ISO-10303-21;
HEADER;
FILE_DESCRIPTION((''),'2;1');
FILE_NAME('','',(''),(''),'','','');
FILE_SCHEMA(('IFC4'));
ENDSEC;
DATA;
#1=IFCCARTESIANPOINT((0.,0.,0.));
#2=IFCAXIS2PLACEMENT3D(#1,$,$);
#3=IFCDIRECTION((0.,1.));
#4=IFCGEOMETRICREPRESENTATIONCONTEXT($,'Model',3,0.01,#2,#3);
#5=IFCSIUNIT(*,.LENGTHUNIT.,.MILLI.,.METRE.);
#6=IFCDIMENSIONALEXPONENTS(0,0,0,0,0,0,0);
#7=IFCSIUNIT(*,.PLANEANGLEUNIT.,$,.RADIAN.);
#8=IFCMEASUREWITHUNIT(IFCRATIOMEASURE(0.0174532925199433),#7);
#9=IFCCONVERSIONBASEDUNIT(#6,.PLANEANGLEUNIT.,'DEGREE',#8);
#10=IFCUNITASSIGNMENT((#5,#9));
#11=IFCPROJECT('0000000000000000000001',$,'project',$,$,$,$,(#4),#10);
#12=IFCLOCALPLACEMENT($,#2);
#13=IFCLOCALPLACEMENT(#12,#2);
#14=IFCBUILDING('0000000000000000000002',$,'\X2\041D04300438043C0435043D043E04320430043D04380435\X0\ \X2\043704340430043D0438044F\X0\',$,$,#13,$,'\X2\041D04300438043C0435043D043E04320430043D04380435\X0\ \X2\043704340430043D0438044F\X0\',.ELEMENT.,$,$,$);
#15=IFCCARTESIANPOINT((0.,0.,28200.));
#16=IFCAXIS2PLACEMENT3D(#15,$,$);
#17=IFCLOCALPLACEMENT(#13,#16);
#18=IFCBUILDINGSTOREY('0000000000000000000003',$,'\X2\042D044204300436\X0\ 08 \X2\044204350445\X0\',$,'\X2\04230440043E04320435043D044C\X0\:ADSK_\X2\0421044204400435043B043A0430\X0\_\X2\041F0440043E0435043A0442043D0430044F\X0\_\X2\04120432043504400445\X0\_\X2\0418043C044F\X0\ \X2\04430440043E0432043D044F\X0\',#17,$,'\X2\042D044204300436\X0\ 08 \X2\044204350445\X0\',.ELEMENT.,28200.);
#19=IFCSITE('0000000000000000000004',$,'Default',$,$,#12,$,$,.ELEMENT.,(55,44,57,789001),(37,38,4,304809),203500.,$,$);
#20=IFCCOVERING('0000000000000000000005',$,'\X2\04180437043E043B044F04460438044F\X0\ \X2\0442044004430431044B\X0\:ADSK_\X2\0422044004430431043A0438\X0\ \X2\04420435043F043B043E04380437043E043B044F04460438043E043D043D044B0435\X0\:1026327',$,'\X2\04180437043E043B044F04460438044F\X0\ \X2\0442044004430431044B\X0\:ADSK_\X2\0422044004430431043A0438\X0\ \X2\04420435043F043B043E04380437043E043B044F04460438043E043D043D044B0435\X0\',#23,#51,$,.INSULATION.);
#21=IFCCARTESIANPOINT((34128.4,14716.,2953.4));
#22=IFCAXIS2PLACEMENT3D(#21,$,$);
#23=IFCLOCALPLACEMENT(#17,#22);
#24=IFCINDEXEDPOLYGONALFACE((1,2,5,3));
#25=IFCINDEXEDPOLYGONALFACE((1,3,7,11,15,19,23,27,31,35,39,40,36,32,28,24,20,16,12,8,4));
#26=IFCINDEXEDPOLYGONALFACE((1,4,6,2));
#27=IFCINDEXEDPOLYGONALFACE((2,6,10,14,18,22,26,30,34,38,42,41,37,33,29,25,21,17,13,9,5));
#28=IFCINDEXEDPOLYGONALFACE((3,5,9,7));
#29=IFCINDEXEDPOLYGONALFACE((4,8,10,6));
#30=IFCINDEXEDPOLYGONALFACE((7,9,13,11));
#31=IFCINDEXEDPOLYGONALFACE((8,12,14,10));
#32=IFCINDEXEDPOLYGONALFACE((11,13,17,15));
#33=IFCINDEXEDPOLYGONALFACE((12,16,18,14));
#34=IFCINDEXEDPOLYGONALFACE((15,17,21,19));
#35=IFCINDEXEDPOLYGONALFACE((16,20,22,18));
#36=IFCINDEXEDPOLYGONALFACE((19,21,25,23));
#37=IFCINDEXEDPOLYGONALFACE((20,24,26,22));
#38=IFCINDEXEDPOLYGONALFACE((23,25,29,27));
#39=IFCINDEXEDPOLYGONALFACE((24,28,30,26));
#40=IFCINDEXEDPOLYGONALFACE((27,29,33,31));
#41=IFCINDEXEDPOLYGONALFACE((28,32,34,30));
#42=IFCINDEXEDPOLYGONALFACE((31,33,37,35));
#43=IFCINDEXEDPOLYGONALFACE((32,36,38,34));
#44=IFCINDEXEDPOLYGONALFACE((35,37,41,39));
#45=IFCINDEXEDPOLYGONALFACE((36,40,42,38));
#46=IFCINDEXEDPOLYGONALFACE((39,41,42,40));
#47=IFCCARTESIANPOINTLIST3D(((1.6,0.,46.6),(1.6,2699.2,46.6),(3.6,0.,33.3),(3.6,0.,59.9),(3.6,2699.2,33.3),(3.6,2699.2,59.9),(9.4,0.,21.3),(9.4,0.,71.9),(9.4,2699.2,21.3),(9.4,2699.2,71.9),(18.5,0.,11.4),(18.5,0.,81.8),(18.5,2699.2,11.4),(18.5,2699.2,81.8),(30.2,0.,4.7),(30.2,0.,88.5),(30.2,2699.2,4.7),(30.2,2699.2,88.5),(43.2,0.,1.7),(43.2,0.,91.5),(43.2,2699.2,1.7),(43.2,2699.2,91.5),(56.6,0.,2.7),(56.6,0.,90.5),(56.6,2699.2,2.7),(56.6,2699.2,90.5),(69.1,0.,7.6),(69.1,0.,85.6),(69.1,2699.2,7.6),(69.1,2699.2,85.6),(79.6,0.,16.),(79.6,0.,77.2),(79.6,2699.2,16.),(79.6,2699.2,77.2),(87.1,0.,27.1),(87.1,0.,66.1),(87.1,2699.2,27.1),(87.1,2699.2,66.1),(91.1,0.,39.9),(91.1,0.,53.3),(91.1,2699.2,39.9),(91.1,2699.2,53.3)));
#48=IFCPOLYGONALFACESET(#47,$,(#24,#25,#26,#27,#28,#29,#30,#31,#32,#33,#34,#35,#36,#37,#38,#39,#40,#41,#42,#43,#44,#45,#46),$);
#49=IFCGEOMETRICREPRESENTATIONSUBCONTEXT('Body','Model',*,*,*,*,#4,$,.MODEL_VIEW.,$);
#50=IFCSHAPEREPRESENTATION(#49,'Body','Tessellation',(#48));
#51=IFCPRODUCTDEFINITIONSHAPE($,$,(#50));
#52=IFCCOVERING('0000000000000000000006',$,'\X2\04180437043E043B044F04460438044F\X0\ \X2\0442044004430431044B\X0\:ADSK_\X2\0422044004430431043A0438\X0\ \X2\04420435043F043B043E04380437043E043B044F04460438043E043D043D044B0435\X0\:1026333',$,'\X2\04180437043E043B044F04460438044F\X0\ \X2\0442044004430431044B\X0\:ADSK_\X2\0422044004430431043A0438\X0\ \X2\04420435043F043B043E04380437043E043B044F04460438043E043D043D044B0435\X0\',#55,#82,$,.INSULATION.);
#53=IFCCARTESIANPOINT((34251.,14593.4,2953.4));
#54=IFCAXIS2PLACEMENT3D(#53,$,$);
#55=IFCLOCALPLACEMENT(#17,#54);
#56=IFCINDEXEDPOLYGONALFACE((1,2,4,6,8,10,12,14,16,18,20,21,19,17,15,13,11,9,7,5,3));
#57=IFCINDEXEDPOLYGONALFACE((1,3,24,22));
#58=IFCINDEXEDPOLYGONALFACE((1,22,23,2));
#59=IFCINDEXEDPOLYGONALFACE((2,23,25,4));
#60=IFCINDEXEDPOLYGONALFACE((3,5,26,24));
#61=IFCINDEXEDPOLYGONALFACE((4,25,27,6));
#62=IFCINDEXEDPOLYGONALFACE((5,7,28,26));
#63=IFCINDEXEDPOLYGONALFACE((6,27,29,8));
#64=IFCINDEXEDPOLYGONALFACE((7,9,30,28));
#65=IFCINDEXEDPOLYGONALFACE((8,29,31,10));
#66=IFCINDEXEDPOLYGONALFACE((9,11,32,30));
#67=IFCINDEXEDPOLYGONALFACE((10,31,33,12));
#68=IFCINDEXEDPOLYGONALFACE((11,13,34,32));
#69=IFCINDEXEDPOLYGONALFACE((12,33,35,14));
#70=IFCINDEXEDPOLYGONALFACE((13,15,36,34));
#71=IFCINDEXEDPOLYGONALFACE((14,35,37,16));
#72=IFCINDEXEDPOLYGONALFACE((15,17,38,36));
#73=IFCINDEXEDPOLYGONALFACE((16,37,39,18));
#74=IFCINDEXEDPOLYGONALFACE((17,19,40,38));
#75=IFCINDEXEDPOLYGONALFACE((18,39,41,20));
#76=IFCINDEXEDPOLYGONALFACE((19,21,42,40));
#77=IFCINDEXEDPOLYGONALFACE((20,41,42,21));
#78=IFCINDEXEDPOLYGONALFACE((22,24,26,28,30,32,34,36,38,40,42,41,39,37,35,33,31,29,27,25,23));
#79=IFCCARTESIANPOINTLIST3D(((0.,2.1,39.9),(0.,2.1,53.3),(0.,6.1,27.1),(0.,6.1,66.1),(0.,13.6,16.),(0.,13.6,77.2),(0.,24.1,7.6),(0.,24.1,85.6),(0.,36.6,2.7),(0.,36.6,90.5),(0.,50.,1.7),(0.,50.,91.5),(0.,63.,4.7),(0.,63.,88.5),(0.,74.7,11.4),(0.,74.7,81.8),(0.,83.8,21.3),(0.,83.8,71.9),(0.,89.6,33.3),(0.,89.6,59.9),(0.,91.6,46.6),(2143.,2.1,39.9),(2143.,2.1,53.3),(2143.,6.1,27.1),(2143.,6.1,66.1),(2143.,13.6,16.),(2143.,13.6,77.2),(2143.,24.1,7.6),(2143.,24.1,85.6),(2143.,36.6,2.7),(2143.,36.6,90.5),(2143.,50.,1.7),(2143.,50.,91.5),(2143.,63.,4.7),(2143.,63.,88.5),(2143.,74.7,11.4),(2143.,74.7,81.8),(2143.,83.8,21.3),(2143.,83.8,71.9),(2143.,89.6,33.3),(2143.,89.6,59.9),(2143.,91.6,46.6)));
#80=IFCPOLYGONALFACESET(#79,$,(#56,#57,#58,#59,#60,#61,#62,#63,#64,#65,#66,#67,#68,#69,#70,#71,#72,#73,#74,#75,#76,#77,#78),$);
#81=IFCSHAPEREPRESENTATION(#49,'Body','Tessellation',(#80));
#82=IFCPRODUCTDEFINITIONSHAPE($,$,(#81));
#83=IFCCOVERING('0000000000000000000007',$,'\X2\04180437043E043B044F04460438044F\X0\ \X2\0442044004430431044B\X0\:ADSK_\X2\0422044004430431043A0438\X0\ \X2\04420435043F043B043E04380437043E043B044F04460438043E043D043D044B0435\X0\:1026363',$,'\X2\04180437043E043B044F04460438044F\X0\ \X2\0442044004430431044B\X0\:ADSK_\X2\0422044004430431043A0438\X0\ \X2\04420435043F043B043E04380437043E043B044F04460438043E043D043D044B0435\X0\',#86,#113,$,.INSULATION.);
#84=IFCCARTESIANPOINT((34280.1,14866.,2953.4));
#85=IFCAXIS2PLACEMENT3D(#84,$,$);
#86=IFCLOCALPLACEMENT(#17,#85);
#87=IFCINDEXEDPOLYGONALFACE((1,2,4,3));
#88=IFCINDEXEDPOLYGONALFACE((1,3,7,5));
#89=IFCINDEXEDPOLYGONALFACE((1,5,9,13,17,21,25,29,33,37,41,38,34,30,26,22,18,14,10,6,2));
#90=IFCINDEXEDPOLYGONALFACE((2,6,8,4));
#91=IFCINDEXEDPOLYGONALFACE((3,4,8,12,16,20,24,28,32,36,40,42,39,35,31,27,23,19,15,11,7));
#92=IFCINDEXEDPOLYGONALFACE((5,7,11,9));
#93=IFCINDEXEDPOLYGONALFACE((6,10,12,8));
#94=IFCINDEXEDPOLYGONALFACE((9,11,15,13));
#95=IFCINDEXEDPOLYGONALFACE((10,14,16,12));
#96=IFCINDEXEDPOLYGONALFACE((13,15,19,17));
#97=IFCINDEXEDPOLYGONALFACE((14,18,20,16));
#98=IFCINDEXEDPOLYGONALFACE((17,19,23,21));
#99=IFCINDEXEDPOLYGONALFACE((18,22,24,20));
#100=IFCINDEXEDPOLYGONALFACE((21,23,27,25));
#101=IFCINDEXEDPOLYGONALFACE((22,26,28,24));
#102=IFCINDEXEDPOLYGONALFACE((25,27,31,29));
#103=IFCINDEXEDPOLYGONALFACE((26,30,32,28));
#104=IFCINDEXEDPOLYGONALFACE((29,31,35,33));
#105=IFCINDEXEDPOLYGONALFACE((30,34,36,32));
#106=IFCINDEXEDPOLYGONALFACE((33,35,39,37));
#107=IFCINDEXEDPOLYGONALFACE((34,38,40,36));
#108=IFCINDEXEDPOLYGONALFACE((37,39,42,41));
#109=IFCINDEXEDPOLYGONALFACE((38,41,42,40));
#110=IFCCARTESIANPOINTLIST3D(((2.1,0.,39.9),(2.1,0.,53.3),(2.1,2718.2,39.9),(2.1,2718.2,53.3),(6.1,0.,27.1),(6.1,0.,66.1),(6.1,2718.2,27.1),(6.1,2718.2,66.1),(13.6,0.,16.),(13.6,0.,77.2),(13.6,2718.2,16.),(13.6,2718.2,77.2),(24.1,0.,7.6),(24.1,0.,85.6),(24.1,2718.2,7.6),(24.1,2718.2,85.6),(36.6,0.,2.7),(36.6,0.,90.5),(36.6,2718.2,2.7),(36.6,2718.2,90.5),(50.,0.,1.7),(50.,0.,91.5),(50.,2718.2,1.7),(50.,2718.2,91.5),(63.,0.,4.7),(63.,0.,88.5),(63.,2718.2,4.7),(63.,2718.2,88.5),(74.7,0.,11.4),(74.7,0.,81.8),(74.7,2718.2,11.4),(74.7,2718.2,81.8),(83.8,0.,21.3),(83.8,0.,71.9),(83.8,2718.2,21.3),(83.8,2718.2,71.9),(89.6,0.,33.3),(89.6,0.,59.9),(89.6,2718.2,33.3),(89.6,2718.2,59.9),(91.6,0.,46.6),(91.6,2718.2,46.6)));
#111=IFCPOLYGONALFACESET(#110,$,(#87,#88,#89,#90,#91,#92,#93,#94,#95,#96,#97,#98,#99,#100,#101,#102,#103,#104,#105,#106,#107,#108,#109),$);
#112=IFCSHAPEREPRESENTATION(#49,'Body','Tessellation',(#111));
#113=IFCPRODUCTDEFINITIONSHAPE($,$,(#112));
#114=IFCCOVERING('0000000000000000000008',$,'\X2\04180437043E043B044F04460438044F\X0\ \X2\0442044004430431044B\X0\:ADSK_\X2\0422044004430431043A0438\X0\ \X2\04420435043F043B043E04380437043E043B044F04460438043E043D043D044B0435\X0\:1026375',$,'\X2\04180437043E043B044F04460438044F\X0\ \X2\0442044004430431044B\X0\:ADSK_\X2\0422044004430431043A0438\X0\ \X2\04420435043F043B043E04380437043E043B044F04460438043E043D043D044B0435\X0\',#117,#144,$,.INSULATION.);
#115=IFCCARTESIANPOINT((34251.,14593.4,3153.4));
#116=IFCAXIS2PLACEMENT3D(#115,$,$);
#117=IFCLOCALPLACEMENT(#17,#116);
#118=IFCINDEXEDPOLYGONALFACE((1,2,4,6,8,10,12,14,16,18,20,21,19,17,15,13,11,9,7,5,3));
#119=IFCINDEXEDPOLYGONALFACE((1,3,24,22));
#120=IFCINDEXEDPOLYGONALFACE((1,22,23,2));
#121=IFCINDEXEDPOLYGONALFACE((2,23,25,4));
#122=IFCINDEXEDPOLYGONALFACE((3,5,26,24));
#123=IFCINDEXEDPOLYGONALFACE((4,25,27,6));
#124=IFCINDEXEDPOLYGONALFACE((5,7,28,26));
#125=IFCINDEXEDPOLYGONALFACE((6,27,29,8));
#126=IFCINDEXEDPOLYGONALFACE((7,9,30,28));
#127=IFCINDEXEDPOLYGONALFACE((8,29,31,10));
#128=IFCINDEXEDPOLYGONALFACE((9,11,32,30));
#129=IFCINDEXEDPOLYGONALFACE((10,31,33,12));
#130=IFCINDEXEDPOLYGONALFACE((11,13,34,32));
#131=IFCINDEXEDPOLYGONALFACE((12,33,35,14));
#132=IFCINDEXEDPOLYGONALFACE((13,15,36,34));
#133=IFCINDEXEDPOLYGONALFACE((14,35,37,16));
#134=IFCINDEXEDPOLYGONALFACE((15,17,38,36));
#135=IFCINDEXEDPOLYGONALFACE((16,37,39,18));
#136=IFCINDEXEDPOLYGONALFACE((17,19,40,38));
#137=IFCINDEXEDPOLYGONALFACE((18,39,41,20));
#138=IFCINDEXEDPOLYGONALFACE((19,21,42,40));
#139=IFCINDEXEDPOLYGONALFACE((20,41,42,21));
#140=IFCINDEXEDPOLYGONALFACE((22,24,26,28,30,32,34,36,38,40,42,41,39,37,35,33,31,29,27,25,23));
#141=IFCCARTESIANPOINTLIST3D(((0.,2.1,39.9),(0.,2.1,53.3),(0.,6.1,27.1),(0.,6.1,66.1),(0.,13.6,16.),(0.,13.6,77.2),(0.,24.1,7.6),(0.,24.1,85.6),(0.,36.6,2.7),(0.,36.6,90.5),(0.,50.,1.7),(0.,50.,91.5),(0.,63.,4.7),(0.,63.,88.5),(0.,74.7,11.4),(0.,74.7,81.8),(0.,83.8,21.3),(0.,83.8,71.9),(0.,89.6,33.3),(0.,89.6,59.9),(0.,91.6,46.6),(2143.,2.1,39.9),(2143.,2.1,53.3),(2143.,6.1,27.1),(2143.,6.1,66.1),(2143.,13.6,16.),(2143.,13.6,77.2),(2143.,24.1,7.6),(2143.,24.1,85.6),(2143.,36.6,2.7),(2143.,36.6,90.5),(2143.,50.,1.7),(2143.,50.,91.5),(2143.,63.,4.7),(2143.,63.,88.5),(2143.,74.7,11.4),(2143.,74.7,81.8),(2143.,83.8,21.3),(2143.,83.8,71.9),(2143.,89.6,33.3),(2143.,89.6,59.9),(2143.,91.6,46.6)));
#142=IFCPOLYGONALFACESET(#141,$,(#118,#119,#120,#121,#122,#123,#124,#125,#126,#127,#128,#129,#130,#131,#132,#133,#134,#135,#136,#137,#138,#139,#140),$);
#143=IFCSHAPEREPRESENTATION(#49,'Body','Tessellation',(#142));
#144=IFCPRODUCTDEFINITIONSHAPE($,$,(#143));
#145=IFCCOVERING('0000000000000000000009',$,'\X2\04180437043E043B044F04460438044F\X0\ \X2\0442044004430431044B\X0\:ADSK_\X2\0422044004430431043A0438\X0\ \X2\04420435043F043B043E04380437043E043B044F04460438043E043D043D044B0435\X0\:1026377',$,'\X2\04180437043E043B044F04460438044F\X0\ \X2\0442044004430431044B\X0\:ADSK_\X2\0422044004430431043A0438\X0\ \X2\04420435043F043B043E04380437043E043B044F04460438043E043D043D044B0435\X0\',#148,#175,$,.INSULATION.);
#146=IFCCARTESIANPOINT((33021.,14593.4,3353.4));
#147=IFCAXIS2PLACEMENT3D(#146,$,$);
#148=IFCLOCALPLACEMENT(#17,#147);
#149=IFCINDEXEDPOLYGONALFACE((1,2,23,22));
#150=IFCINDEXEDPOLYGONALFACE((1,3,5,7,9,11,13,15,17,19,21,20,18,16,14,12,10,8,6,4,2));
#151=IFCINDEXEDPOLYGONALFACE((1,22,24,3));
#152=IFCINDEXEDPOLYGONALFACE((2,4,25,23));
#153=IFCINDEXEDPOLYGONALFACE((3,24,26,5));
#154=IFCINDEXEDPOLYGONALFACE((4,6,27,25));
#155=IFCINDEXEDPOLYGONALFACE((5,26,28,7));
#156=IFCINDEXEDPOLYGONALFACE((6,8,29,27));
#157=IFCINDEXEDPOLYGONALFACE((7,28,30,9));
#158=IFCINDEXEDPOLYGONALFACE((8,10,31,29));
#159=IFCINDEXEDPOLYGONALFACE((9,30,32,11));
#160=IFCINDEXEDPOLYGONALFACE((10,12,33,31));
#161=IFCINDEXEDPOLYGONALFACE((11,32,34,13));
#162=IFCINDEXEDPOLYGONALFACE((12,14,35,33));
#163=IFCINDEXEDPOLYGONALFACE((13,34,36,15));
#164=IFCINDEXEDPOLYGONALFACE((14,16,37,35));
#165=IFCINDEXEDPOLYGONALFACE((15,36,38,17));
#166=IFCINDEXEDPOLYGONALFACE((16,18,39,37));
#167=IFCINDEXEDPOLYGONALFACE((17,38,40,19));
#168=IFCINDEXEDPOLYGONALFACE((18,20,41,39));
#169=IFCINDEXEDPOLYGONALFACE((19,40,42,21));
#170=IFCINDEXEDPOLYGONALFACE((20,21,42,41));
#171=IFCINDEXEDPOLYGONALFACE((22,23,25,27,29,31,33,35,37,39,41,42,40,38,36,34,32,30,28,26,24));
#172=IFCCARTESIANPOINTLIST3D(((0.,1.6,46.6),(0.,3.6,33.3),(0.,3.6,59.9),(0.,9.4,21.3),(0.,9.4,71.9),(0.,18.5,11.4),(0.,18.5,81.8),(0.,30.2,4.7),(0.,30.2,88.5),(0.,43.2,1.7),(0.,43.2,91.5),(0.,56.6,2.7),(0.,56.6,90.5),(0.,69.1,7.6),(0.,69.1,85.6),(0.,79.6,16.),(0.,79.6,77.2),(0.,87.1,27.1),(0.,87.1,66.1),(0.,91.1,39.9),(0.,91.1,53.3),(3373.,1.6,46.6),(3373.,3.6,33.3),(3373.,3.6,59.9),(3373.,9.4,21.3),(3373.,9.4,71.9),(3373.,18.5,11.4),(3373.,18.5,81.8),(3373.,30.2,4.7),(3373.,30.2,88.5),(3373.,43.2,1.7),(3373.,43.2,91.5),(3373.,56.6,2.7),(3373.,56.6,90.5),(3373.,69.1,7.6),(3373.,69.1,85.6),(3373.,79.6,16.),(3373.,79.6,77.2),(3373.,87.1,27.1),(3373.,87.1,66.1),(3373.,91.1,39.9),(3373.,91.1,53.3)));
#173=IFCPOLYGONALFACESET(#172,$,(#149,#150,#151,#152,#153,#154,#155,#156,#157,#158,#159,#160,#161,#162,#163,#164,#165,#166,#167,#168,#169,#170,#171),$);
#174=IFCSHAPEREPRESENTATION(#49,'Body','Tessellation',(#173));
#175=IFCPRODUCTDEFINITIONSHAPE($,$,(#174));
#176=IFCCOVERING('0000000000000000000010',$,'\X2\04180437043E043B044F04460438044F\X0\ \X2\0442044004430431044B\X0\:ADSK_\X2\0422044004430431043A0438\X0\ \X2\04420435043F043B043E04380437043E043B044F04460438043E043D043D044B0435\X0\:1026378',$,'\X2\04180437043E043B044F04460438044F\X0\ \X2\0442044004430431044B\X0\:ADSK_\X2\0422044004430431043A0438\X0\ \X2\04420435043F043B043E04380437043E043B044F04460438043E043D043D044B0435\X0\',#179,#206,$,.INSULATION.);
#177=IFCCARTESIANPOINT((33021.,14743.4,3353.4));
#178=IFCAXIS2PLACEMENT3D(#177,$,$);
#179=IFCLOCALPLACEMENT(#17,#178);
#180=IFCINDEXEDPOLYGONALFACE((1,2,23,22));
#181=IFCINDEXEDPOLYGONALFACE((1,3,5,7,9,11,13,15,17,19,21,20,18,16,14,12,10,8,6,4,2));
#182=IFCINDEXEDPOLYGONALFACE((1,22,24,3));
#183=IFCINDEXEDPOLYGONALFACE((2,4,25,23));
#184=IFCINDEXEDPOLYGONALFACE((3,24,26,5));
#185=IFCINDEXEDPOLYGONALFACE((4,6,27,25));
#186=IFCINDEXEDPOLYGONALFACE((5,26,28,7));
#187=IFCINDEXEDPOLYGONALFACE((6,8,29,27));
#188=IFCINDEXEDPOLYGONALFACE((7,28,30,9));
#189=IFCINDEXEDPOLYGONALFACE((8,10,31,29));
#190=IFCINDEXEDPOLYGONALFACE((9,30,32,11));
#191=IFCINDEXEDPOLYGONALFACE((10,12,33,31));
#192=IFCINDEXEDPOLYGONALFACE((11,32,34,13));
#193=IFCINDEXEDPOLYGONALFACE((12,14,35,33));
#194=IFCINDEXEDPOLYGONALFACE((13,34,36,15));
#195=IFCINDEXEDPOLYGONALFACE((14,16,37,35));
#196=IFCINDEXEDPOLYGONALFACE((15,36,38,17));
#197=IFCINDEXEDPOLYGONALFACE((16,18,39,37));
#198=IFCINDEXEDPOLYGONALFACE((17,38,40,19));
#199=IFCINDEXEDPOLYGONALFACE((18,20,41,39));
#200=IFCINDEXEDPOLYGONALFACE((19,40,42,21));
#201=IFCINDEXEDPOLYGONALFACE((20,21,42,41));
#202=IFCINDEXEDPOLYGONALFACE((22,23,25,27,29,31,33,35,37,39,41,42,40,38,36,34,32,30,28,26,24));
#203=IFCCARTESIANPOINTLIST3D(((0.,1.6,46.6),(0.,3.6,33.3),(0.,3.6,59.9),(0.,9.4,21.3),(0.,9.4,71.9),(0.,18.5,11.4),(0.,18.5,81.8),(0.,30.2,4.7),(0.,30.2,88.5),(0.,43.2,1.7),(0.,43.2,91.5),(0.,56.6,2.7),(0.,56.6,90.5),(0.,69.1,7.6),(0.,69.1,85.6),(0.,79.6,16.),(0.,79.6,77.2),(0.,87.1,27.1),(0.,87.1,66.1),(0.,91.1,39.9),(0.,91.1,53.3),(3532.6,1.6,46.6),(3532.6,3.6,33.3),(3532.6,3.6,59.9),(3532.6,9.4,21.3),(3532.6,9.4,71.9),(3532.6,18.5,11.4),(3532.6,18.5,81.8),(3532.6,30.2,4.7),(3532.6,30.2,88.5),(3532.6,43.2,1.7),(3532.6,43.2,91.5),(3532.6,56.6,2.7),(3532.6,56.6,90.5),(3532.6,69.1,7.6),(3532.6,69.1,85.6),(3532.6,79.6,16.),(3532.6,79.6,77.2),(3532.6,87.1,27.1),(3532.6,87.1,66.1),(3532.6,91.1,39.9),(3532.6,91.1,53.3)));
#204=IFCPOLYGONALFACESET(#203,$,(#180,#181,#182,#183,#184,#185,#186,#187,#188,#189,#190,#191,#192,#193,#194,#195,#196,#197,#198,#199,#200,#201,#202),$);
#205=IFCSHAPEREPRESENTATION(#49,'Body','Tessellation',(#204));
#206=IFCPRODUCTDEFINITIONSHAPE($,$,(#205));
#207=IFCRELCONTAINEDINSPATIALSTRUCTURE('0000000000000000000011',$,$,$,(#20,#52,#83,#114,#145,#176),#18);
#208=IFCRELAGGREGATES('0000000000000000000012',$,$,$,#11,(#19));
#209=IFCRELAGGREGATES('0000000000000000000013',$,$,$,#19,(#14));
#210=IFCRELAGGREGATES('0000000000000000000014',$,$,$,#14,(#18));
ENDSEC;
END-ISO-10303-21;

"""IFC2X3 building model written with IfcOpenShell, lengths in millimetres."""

from ifc_helpers import new_model, entity, si_unit, converted_unit, direction, frame, origin, origin_2d_with_axis, place, context, subcontext, project, spatial, circle, extrude, element, save


model = new_model("IFC2X3")

# Units and contexts
model_context = context("Model", 3, precision=0.01, world=origin(), true_north=direction((0.0, 1.0)))
body_context = subcontext(model_context, "Body", "Model", "MODEL_VIEW")
ifc_project = project(units=[si_unit("LENGTHUNIT", "METRE", prefix="MILLI"), converted_unit("PLANEANGLEUNIT", "DEGREE", entity("IfcRatioMeasure", 0.0174532925199433), si_unit("PLANEANGLEUNIT", "RADIAN"), dimensions=[0, 0, 0, 0, 0, 0, 0])], contexts=[model_context])

# Site, building, storey
site_placement = place(None, origin())
site = spatial("IfcSite", under=ifc_project, at=site_placement, Name="Default", CompositionType="ELEMENT", RefLatitude=(55, 44, 57, 789001), RefLongitude=(37, 38, 4, 304809), RefElevation=203500.0)
building_placement = place(site_placement, origin())
building = spatial("IfcBuilding", under=site, at=building_placement, Name="Наименование здания", LongName="Наименование здания", CompositionType="ELEMENT")
storey_placement = place(building_placement, frame((0.0, 0.0, 28200.0)))
storey = spatial("IfcBuildingStorey", under=building, at=storey_placement, Name="Этаж 08 тех", ObjectType="Уровень:ADSK_Стрелка_Проектная_Вверх_Имя уровня", LongName="Этаж 08 тех", CompositionType="ELEMENT", Elevation=28200.0)

# Coverings
covering_1_placement = place(storey_placement, frame((34128.4, 14716.0, 2953.4)))
element("IfcCovering", 1, at=covering_1_placement, inside=storey, Name="Изоляция трубы:ADSK_Трубки теплоизоляционные:1026327", ObjectType="Изоляция трубы:ADSK_Трубки теплоизоляционные", PredefinedType="INSULATION", context=body_context, shape_type="SweptSolid", body=[
    extrude(circle(Radius=45.0, at=origin_2d_with_axis()), frame((46.6, 0.0, 46.6), z_axis=(0.0, 1.0, 0.0), x_axis=(-1.0, 0.0, 0.0)), (0.0, 0.0, 1.0), 2699.2),
])
covering_2_placement = place(storey_placement, frame((34251.0, 14593.4, 2953.4)))
element("IfcCovering", 2, at=covering_2_placement, inside=storey, Name="Изоляция трубы:ADSK_Трубки теплоизоляционные:1026333", ObjectType="Изоляция трубы:ADSK_Трубки теплоизоляционные", PredefinedType="INSULATION", context=body_context, shape_type="SweptSolid", body=[
    extrude(circle(Radius=45.0, at=origin_2d_with_axis()), frame((0.0, 46.6, 46.6), z_axis=(1.0, 0.0, 0.0), x_axis=(0.0, 1.0, 0.0)), (0.0, 0.0, 1.0), 2143.0),
])
covering_3_placement = place(storey_placement, frame((34280.1, 14866.0, 2953.4)))
element("IfcCovering", 3, at=covering_3_placement, inside=storey, Name="Изоляция трубы:ADSK_Трубки теплоизоляционные:1026363", ObjectType="Изоляция трубы:ADSK_Трубки теплоизоляционные", PredefinedType="INSULATION", context=body_context, shape_type="SweptSolid", body=[
    extrude(circle(Radius=45.0, at=origin_2d_with_axis()), frame((46.6, 0.0, 46.6), z_axis=(0.0, 1.0, 0.0), x_axis=(1.0, 0.0, 0.0)), (0.0, 0.0, 1.0), 2718.2),
])
covering_4_placement = place(storey_placement, frame((34251.0, 14593.4, 3153.4)))
element("IfcCovering", 4, at=covering_4_placement, inside=storey, Name="Изоляция трубы:ADSK_Трубки теплоизоляционные:1026375", ObjectType="Изоляция трубы:ADSK_Трубки теплоизоляционные", PredefinedType="INSULATION", context=body_context, shape_type="SweptSolid", body=[
    extrude(circle(Radius=45.0, at=origin_2d_with_axis()), frame((0.0, 46.6, 46.6), z_axis=(1.0, 0.0, 0.0), x_axis=(0.0, 1.0, 0.0)), (0.0, 0.0, 1.0), 2143.0),
])
covering_5_placement = place(storey_placement, frame((33021.0, 14593.4, 3353.4)))
element("IfcCovering", 5, at=covering_5_placement, inside=storey, Name="Изоляция трубы:ADSK_Трубки теплоизоляционные:1026377", ObjectType="Изоляция трубы:ADSK_Трубки теплоизоляционные", PredefinedType="INSULATION", context=body_context, shape_type="SweptSolid", body=[
    extrude(circle(Radius=45.0, at=origin_2d_with_axis()), frame((0.0, 46.6, 46.6), z_axis=(1.0, 0.0, 0.0), x_axis=(0.0, -1.0, 0.0)), (0.0, 0.0, 1.0), 3373.0),
])
covering_6_placement = place(storey_placement, frame((33021.0, 14743.4, 3353.4)))
element("IfcCovering", 6, at=covering_6_placement, inside=storey, Name="Изоляция трубы:ADSK_Трубки теплоизоляционные:1026378", ObjectType="Изоляция трубы:ADSK_Трубки теплоизоляционные", PredefinedType="INSULATION", context=body_context, shape_type="SweptSolid", body=[
    extrude(circle(Radius=45.0, at=origin_2d_with_axis()), frame((0.0, 46.6, 46.6), z_axis=(1.0, 0.0, 0.0), x_axis=(0.0, -1.0, 0.0)), (0.0, 0.0, 1.0), 3532.6),
])

save(model, "model.ifc")
